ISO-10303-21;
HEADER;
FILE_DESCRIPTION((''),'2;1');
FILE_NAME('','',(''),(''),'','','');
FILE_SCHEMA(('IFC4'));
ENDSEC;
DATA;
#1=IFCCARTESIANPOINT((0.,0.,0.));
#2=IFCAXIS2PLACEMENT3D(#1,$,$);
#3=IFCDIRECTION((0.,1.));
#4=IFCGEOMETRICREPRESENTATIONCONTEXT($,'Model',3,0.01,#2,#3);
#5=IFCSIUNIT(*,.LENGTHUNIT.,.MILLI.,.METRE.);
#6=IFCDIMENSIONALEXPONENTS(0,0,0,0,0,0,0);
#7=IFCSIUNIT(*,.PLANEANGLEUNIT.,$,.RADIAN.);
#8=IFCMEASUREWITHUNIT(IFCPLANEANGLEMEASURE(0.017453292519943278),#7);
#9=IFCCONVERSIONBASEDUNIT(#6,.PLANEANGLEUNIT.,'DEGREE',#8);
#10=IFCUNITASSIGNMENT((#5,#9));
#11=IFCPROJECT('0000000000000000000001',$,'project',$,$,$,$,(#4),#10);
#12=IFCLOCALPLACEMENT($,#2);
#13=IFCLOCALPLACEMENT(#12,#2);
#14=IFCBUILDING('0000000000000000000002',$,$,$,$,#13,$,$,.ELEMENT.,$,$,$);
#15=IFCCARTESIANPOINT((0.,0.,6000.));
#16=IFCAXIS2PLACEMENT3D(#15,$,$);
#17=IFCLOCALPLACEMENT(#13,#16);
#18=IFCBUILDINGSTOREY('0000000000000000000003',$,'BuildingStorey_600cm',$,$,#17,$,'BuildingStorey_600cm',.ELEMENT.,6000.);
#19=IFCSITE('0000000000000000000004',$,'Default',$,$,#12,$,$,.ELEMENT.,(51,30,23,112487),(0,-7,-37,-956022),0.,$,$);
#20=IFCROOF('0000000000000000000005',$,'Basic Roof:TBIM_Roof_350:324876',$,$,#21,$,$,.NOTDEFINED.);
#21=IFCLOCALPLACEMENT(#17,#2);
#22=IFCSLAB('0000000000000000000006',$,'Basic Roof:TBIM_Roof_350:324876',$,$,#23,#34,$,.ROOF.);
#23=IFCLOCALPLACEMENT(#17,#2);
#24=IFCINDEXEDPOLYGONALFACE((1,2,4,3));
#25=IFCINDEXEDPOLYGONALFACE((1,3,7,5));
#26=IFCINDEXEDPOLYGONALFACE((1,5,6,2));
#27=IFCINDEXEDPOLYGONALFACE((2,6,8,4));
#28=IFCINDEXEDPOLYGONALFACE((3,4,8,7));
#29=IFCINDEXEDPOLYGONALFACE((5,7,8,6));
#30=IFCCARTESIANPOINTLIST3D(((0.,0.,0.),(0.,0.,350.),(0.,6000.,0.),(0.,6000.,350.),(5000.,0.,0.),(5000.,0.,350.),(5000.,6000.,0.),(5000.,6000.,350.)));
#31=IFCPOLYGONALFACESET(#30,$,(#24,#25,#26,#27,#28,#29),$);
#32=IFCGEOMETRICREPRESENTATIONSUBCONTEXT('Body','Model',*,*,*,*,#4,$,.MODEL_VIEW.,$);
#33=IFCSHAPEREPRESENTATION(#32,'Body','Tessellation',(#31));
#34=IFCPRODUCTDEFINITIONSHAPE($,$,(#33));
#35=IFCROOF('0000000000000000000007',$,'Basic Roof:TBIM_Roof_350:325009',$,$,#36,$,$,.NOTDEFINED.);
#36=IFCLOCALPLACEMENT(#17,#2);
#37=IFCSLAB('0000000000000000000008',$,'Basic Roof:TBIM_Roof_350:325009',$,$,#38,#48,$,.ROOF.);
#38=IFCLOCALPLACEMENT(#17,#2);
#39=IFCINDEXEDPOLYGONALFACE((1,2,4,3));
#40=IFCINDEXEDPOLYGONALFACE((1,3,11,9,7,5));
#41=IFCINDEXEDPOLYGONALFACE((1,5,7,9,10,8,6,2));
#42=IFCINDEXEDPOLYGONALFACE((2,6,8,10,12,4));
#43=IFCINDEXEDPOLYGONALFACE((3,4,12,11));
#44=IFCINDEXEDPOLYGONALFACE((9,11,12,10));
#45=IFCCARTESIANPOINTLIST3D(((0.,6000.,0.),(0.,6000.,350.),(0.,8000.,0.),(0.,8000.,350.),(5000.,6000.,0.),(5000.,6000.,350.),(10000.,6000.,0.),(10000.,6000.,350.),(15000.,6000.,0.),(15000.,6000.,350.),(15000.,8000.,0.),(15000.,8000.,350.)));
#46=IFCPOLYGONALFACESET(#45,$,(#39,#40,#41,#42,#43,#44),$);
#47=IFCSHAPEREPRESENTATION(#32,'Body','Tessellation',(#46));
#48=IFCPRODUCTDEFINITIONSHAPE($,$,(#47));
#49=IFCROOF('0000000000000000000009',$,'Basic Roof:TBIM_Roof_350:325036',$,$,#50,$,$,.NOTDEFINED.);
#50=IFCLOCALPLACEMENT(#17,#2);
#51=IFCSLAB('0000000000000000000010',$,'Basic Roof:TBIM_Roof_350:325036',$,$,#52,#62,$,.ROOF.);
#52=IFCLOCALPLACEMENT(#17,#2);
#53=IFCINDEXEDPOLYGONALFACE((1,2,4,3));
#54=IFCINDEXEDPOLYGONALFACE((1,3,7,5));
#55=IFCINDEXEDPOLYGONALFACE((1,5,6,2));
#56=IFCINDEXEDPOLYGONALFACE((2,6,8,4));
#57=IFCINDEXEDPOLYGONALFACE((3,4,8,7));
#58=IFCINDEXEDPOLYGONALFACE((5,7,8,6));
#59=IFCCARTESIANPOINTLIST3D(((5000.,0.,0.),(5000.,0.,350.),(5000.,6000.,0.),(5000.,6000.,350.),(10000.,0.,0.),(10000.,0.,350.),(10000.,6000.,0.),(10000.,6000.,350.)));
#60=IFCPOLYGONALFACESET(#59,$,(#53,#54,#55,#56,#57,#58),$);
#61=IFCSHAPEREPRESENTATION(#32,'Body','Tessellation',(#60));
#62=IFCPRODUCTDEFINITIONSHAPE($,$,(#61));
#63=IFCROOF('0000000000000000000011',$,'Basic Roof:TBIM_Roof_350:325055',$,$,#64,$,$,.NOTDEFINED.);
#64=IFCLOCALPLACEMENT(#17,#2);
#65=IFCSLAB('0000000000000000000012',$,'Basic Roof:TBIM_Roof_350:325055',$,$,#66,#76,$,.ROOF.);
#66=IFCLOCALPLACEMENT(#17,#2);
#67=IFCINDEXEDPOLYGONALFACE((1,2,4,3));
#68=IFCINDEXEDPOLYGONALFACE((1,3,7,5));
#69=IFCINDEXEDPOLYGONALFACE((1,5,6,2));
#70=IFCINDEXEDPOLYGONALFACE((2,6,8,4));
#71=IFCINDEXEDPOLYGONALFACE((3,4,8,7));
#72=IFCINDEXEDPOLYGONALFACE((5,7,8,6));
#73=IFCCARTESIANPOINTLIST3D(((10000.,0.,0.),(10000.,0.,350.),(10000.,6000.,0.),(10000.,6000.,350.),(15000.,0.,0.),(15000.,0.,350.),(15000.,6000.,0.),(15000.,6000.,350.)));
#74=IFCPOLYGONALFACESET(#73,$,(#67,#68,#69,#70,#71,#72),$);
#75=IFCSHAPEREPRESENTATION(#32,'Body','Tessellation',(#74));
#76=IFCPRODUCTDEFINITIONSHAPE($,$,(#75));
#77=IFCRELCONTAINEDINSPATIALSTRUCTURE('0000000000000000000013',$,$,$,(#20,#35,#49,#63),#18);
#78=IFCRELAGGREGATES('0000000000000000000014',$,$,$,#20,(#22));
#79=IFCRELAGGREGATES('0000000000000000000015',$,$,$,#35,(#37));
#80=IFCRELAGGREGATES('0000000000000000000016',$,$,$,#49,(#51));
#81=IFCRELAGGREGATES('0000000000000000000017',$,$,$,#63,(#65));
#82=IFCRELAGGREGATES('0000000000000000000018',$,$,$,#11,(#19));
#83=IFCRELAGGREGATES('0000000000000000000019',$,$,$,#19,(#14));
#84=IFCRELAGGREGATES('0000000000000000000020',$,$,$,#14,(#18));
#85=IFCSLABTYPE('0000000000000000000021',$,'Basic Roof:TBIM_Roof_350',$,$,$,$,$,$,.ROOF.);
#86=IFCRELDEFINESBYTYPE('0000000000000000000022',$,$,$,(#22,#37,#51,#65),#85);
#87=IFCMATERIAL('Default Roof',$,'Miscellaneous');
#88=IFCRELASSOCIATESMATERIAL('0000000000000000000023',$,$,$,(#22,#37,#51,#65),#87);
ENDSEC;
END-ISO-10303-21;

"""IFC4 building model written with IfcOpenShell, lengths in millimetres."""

from ifc_helpers import new_model, entity, si_unit, converted_unit, direction, frame, origin, place, context, subcontext, project, spatial, indexed_curve, outline, extrude, material, type_object, element, aggregate, save


model = new_model("IFC4")

# Units and contexts
model_context = context("Model", 3, precision=0.01, world=origin(), true_north=direction((0.0, 1.0)))
body_context = subcontext(model_context, "Body", "Model", "MODEL_VIEW")
ifc_project = project(units=[si_unit("LENGTHUNIT", "METRE", prefix="MILLI"), converted_unit("PLANEANGLEUNIT", "DEGREE", entity("IfcPlaneAngleMeasure", 0.017453292519943278), si_unit("PLANEANGLEUNIT", "RADIAN"), dimensions=[0, 0, 0, 0, 0, 0, 0])], contexts=[model_context])

# Site, building, storey
site_placement = place(None, origin())
site = spatial("IfcSite", under=ifc_project, at=site_placement, Name="Default", CompositionType="ELEMENT", RefLatitude=(51, 30, 23, 112487), RefLongitude=(0, -7, -37, -956022), RefElevation=0.0)
building_placement = place(site_placement, origin())
building = spatial("IfcBuilding", under=site, at=building_placement, CompositionType="ELEMENT")
storey_placement = place(building_placement, frame((0.0, 0.0, 6000.0)))
storey = spatial("IfcBuildingStorey", under=building, at=storey_placement, Name="BuildingStorey_600cm", LongName="BuildingStorey_600cm", CompositionType="ELEMENT", Elevation=6000.0)

# Roofs, slabs
roof_1_placement = place(storey_placement, origin())
roof_1 = element("IfcRoof", 1, at=roof_1_placement, inside=storey, Name="Basic Roof:TBIM_Roof_350:324876", PredefinedType="NOTDEFINED")
ifc_material = material(Name="Default Roof", Category="Miscellaneous")
slab_type = type_object("IfcSlabType", Name="Basic Roof:TBIM_Roof_350", PredefinedType="ROOF")
slab_1_placement = place(roof_1_placement, origin())
slab_1 = element("IfcSlab", 2, at=slab_1_placement, type_object=slab_type, material=ifc_material, Name="Basic Roof:TBIM_Roof_350:324876", PredefinedType="ROOF", context=body_context, shape_type="SweptSolid", body=[
    extrude(outline(indexed_curve([(-2500.0, 3000.0), (-2500.0, -3000.0), (2500.0, -3000.0), (2500.0, 3000.0), (-2500.0, 3000.0)], self_intersect=False)), frame((2500.0, 3000.0, 0.0)), (0.0, 0.0, 1.0), 350.0),
])
aggregate(roof_1, [slab_1])
roof_2_placement = place(storey_placement, frame((0.0, 6000.0, 0.0)))
roof_2 = element("IfcRoof", 3, at=roof_2_placement, inside=storey, Name="Basic Roof:TBIM_Roof_350:325009", PredefinedType="NOTDEFINED")
slab_2_placement = place(roof_2_placement, origin())
slab_2 = element("IfcSlab", 4, at=slab_2_placement, type_object=slab_type, material=ifc_material, Name="Basic Roof:TBIM_Roof_350:325009", PredefinedType="ROOF", context=body_context, shape_type="SweptSolid", body=[
    extrude(outline(indexed_curve([(-7500.0, 1000.0), (-7500.0, -1000.0), (-2500.0, -1000.0), (2500.0, -1000.0), (7500.0, -1000.0), (7500.0, 1000.0), (-7500.0, 1000.0)], self_intersect=False)), frame((7500.0, 1000.0, 0.0)), (0.0, 0.0, 1.0), 350.0),
])
aggregate(roof_2, [slab_2])
roof_3_placement = place(storey_placement, frame((5000.0, 0.0, 0.0)))
roof_3 = element("IfcRoof", 5, at=roof_3_placement, inside=storey, Name="Basic Roof:TBIM_Roof_350:325036", PredefinedType="NOTDEFINED")
slab_3_placement = place(roof_3_placement, origin())
slab_3 = element("IfcSlab", 6, at=slab_3_placement, type_object=slab_type, material=ifc_material, Name="Basic Roof:TBIM_Roof_350:325036", PredefinedType="ROOF", context=body_context, shape_type="SweptSolid", body=[
    extrude(outline(indexed_curve([(-2500.0, 3000.0), (-2500.0, -3000.0), (2500.0, -3000.0), (2500.0, 3000.0), (-2500.0, 3000.0)], self_intersect=False)), frame((2500.0, 3000.0, 0.0)), (0.0, 0.0, 1.0), 350.0),
])
aggregate(roof_3, [slab_3])
roof_4_placement = place(storey_placement, frame((10000.0, 0.0, 0.0)))
roof_4 = element("IfcRoof", 7, at=roof_4_placement, inside=storey, Name="Basic Roof:TBIM_Roof_350:325055", PredefinedType="NOTDEFINED")
slab_4_placement = place(roof_4_placement, origin())
slab_4 = element("IfcSlab", 8, at=slab_4_placement, type_object=slab_type, material=ifc_material, Name="Basic Roof:TBIM_Roof_350:325055", PredefinedType="ROOF", context=body_context, shape_type="SweptSolid", body=[
    extrude(outline(indexed_curve([(-2500.0, 3000.0), (-2500.0, -3000.0), (2500.0, -3000.0), (2500.0, 3000.0), (-2500.0, 3000.0)], self_intersect=False)), frame((2500.0, 3000.0, 0.0)), (0.0, 0.0, 1.0), 350.0),
])
aggregate(roof_4, [slab_4])

save(model, "model.ifc")
